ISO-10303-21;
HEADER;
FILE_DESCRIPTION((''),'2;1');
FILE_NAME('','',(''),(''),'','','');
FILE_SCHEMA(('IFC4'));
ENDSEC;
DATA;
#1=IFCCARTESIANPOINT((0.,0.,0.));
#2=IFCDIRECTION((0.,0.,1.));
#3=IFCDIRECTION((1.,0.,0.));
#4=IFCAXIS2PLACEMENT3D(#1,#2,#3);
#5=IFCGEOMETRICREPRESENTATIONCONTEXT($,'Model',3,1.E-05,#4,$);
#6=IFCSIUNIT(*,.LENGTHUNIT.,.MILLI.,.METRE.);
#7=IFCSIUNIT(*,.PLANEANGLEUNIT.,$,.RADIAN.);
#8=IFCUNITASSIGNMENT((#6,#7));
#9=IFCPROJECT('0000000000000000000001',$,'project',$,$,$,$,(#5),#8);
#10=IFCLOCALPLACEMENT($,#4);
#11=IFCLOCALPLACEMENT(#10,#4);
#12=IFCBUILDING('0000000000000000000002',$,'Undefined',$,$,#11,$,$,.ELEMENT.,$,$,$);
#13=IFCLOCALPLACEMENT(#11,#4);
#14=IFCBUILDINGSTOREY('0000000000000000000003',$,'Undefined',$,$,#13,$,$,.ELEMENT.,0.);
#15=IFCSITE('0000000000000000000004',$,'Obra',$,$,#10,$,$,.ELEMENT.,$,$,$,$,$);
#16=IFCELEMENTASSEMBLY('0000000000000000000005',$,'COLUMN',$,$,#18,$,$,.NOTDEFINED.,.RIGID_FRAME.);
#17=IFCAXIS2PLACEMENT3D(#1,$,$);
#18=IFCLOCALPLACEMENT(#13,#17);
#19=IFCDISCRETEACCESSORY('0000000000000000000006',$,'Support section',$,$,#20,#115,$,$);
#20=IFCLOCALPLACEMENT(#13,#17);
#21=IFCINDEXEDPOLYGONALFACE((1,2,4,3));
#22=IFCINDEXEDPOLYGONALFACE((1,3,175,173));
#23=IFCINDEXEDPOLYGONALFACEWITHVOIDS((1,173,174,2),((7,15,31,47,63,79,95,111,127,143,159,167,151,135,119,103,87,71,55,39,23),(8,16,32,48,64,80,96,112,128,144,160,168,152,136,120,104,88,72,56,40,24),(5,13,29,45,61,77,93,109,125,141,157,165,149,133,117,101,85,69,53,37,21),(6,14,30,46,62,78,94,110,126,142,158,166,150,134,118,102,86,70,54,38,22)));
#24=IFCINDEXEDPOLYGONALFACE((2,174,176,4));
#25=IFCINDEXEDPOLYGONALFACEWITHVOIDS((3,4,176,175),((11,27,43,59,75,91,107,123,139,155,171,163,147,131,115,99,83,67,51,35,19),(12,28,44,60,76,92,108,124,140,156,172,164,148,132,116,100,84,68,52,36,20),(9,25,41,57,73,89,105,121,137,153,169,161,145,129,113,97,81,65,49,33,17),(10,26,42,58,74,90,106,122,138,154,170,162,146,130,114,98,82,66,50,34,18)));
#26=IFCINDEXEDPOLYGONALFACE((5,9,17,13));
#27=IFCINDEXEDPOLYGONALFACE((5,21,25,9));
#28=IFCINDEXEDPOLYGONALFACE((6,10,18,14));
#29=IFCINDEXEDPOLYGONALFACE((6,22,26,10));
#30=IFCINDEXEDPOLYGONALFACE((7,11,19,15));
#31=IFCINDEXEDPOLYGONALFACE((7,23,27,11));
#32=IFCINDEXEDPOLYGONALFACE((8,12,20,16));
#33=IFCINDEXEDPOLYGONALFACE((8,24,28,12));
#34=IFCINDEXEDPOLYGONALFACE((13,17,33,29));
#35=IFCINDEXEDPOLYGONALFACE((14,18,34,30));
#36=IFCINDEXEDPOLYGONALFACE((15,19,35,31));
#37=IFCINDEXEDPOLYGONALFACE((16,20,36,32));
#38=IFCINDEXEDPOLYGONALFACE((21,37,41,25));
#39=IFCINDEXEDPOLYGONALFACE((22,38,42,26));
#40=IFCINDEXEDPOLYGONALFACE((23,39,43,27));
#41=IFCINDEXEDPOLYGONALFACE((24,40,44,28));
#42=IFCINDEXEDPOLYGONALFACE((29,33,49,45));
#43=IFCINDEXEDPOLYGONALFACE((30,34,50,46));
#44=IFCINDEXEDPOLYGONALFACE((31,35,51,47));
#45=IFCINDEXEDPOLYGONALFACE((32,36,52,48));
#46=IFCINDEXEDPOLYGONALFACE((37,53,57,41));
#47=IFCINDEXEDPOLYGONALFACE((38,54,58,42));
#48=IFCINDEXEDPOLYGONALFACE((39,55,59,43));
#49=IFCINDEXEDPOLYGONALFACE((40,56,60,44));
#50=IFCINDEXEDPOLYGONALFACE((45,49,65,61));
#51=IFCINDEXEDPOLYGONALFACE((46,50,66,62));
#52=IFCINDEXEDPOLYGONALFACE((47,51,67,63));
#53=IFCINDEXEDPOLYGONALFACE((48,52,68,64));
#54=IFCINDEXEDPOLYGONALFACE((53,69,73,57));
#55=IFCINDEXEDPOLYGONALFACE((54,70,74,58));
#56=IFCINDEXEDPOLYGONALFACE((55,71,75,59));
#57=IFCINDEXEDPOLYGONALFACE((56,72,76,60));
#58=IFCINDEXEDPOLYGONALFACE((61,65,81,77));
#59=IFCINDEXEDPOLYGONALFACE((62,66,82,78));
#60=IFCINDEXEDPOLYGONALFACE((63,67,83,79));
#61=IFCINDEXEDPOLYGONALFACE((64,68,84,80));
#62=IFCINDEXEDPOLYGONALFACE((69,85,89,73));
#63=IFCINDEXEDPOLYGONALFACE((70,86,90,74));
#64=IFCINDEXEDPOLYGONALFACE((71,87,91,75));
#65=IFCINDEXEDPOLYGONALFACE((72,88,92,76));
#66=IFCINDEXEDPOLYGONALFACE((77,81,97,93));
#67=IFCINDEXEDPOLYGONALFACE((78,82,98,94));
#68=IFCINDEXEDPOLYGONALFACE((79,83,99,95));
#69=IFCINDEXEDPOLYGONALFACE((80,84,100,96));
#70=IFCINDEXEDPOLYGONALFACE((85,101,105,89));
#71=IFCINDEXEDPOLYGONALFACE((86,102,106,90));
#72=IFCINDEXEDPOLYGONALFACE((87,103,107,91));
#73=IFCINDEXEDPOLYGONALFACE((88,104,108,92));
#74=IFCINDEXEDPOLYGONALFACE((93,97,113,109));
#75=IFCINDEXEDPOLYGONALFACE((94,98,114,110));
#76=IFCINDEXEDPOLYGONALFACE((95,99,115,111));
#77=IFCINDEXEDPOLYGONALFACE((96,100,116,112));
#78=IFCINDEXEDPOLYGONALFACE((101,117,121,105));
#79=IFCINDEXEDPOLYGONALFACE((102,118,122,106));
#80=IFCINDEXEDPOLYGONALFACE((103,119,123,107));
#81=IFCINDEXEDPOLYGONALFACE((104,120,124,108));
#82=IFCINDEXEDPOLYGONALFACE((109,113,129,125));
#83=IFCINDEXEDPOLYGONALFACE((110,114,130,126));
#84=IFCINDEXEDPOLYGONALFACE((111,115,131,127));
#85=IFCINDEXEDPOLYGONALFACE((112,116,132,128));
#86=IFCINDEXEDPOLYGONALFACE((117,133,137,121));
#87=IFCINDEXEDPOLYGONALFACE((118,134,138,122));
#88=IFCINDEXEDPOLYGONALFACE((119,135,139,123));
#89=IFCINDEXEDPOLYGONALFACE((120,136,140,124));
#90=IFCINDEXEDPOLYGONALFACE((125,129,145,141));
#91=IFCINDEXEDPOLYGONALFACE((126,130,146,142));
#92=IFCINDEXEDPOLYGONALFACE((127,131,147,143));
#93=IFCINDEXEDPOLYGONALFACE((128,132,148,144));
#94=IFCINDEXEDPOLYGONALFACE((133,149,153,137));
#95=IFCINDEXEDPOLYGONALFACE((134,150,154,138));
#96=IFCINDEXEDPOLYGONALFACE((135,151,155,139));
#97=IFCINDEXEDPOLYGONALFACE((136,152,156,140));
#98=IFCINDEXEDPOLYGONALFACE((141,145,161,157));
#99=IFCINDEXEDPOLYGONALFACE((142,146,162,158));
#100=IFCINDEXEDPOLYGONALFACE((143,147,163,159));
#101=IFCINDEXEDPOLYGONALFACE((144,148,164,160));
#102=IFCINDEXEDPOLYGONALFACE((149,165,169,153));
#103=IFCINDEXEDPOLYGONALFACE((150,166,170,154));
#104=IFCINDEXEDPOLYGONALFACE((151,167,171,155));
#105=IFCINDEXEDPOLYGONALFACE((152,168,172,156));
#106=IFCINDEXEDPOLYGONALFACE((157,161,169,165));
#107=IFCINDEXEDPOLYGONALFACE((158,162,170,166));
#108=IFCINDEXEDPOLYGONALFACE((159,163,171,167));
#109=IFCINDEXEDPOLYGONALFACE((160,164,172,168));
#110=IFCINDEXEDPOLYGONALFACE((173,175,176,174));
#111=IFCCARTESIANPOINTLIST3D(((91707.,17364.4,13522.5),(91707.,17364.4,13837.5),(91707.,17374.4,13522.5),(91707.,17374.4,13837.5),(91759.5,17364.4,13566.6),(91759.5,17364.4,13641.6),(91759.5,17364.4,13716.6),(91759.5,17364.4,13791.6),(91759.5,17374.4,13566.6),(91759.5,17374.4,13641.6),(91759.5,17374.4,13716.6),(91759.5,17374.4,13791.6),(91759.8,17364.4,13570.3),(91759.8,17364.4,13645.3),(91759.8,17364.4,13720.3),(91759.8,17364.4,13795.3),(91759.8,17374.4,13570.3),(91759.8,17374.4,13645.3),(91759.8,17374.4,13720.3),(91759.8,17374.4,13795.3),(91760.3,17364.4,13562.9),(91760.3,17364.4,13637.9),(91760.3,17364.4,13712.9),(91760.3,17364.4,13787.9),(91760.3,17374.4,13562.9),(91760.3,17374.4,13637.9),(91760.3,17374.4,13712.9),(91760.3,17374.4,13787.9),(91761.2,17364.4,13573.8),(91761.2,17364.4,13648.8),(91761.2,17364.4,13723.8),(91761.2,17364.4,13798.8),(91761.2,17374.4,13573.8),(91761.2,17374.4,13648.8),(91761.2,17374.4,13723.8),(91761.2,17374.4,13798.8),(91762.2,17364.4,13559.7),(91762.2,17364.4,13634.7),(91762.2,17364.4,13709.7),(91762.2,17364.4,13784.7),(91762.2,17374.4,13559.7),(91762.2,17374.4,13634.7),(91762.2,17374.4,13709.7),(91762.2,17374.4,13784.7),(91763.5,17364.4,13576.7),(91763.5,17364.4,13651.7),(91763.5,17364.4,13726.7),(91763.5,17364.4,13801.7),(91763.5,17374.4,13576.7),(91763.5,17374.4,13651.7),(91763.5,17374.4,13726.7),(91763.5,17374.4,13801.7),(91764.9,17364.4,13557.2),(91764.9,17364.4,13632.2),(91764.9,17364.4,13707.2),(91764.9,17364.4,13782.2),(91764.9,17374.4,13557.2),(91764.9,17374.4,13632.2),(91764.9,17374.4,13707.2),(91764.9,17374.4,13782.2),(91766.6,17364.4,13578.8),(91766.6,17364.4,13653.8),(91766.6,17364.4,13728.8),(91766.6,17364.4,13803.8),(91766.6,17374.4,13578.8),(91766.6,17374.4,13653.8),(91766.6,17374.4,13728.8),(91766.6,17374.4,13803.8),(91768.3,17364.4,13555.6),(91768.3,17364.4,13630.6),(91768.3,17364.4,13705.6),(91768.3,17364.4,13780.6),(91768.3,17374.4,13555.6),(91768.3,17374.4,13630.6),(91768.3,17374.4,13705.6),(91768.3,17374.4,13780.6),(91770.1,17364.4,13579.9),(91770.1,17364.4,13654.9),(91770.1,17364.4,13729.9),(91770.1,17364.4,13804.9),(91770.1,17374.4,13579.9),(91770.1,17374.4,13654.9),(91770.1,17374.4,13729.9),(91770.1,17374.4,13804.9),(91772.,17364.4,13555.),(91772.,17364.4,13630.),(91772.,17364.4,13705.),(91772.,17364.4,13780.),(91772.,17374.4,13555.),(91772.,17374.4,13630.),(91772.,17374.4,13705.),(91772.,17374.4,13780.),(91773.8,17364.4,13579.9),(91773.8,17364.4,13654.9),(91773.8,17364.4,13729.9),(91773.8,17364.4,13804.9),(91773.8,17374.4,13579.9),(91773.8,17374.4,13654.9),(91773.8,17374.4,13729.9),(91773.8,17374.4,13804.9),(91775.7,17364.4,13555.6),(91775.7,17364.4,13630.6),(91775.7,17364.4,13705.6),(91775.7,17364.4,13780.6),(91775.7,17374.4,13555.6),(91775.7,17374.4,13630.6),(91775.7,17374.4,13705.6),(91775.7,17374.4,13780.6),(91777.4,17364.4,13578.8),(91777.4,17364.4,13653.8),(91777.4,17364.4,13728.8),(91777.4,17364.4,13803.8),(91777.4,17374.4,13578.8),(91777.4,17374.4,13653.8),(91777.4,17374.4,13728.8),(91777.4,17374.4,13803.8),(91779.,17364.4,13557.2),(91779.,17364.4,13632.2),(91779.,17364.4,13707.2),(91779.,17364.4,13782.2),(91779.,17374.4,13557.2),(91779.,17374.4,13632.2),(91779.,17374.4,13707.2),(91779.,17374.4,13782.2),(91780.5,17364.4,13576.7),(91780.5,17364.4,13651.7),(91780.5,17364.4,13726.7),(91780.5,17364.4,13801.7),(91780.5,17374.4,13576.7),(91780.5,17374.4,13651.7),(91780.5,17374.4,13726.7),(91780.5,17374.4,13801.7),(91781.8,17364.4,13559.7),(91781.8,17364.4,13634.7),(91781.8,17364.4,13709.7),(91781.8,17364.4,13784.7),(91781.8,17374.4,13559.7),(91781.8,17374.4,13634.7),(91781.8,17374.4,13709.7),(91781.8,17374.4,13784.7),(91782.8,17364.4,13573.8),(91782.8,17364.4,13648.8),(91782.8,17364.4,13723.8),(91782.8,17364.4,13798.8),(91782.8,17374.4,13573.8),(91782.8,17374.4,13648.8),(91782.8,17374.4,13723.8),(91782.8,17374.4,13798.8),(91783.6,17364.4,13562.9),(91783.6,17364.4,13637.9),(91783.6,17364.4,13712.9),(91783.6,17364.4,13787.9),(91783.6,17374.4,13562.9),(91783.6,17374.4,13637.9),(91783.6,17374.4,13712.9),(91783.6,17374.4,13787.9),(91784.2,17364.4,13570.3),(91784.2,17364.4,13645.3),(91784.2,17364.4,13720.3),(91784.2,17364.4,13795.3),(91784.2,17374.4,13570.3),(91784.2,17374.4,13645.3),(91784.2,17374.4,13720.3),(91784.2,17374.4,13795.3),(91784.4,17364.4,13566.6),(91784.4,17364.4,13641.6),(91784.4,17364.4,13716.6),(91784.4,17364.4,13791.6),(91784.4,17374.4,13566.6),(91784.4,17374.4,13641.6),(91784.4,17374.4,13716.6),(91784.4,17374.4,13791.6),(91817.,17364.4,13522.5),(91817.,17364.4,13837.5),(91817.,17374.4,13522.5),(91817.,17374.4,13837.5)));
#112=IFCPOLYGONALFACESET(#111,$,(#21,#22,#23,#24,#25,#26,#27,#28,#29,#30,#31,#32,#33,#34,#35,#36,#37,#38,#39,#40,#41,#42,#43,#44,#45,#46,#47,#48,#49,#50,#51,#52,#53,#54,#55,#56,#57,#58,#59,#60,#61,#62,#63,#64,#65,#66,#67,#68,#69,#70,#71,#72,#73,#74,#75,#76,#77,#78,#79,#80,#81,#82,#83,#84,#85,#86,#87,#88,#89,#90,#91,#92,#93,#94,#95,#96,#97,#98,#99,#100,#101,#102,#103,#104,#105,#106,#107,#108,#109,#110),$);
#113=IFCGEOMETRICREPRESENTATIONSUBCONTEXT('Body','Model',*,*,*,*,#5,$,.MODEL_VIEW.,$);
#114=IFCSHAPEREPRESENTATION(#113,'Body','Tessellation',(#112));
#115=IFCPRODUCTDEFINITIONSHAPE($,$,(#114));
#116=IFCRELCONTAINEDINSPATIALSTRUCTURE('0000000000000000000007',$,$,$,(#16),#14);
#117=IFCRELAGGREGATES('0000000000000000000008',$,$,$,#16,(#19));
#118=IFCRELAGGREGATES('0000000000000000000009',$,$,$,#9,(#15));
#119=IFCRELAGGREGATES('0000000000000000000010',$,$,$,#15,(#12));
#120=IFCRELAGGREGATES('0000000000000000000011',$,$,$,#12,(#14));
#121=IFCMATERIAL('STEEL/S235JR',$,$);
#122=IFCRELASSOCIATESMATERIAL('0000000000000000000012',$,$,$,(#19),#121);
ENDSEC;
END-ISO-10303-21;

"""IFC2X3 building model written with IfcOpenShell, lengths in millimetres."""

from ifc_helpers import new_model, si_unit, frame, origin_with_axes, origin_2d_with_axis, place, context, subcontext, project, spatial, rectangle, circle, extrude, source, transform, mapped, material, element, aggregate, save


model = new_model("IFC2X3")

# Units and contexts
model_context = context("Model", 3, precision=1e-05, world=origin_with_axes())
body_context = subcontext(model_context, "Body", "Model", "MODEL_VIEW")
ifc_project = project(units=[si_unit("LENGTHUNIT", "METRE", prefix="MILLI"), si_unit("PLANEANGLEUNIT", "RADIAN")], contexts=[model_context])

# Site, building, storey
site_placement = place(None, origin_with_axes())
site = spatial("IfcSite", under=ifc_project, at=site_placement, Name="Obra", CompositionType="ELEMENT")
building_placement = place(site_placement, origin_with_axes())
building = spatial("IfcBuilding", under=site, at=building_placement, Name="Undefined", CompositionType="ELEMENT")
storey_placement = place(building_placement, origin_with_axes())
storey = spatial("IfcBuildingStorey", under=building, at=storey_placement, Name="Undefined", CompositionType="ELEMENT", Elevation=0.0)

# Element assembly
assembly_1_placement = place(storey_placement, origin_with_axes())
assembly_1 = element("IfcElementAssembly", 1, at=assembly_1_placement, inside=storey, Name="COLUMN", AssemblyPlace="NOTDEFINED", PredefinedType="RIGID_FRAME")
ifc_material_1 = material(Name="STEEL/S235JR")

# Discrete accessory, opening
discrete_accessory_1_placement = place(assembly_1_placement, frame((91762.0, 17369.4, 13522.5), z_axis=(0.0, 0.0, 1.0), x_axis=(-1.0, 0.0, 0.0)))
discrete_accessory_1 = element("IfcDiscreteAccessory", 2, at=discrete_accessory_1_placement, material=ifc_material_1, Name="Support section", context=body_context, shape_type="SweptSolid", body=[
    extrude(rectangle(XDim=10.0, YDim=110.0, at=origin_2d_with_axis()), frame((0.0, 0.0, 315.0), z_axis=(0.0, 0.0, -1.0), x_axis=(0.0, 1.0, 0.0)), (0.0, 0.0, 1.0), 315.0),
])
shared_shape_1 = source(origin_with_axes(), body_context, "Body", "SweptSolid", [
    extrude(circle(Radius=12.5, at=origin_2d_with_axis()), frame((0.0, -15.8, 0.0), z_axis=(0.0, 1.0, 0.0), x_axis=(1.0, 0.0, 0.0)), (0.0, 0.0, 1.0), 10.2),
])
opening_1_placement = place(assembly_1_placement, frame((91727.0, 17380.1, 13900.0), z_axis=(1.0, 0.0, 0.0), x_axis=(0.0, 0.0, -1.0)))
element("IfcOpeningElement", 3, at=opening_1_placement, cuts=discrete_accessory_1, ObjectType="Opening", context=body_context, shape_type="MappedRepresentation", body=[
    mapped(shared_shape_1, transform((107.5, 0.0, 45.0))),
    mapped(shared_shape_1, transform((182.5, 0.0, 45.0))),
    mapped(shared_shape_1, transform((257.5, 0.0, 45.0))),
    mapped(shared_shape_1, transform((332.5, 0.0, 45.0))),
])

aggregate(assembly_1, [discrete_accessory_1])

save(model, "model.ifc")
